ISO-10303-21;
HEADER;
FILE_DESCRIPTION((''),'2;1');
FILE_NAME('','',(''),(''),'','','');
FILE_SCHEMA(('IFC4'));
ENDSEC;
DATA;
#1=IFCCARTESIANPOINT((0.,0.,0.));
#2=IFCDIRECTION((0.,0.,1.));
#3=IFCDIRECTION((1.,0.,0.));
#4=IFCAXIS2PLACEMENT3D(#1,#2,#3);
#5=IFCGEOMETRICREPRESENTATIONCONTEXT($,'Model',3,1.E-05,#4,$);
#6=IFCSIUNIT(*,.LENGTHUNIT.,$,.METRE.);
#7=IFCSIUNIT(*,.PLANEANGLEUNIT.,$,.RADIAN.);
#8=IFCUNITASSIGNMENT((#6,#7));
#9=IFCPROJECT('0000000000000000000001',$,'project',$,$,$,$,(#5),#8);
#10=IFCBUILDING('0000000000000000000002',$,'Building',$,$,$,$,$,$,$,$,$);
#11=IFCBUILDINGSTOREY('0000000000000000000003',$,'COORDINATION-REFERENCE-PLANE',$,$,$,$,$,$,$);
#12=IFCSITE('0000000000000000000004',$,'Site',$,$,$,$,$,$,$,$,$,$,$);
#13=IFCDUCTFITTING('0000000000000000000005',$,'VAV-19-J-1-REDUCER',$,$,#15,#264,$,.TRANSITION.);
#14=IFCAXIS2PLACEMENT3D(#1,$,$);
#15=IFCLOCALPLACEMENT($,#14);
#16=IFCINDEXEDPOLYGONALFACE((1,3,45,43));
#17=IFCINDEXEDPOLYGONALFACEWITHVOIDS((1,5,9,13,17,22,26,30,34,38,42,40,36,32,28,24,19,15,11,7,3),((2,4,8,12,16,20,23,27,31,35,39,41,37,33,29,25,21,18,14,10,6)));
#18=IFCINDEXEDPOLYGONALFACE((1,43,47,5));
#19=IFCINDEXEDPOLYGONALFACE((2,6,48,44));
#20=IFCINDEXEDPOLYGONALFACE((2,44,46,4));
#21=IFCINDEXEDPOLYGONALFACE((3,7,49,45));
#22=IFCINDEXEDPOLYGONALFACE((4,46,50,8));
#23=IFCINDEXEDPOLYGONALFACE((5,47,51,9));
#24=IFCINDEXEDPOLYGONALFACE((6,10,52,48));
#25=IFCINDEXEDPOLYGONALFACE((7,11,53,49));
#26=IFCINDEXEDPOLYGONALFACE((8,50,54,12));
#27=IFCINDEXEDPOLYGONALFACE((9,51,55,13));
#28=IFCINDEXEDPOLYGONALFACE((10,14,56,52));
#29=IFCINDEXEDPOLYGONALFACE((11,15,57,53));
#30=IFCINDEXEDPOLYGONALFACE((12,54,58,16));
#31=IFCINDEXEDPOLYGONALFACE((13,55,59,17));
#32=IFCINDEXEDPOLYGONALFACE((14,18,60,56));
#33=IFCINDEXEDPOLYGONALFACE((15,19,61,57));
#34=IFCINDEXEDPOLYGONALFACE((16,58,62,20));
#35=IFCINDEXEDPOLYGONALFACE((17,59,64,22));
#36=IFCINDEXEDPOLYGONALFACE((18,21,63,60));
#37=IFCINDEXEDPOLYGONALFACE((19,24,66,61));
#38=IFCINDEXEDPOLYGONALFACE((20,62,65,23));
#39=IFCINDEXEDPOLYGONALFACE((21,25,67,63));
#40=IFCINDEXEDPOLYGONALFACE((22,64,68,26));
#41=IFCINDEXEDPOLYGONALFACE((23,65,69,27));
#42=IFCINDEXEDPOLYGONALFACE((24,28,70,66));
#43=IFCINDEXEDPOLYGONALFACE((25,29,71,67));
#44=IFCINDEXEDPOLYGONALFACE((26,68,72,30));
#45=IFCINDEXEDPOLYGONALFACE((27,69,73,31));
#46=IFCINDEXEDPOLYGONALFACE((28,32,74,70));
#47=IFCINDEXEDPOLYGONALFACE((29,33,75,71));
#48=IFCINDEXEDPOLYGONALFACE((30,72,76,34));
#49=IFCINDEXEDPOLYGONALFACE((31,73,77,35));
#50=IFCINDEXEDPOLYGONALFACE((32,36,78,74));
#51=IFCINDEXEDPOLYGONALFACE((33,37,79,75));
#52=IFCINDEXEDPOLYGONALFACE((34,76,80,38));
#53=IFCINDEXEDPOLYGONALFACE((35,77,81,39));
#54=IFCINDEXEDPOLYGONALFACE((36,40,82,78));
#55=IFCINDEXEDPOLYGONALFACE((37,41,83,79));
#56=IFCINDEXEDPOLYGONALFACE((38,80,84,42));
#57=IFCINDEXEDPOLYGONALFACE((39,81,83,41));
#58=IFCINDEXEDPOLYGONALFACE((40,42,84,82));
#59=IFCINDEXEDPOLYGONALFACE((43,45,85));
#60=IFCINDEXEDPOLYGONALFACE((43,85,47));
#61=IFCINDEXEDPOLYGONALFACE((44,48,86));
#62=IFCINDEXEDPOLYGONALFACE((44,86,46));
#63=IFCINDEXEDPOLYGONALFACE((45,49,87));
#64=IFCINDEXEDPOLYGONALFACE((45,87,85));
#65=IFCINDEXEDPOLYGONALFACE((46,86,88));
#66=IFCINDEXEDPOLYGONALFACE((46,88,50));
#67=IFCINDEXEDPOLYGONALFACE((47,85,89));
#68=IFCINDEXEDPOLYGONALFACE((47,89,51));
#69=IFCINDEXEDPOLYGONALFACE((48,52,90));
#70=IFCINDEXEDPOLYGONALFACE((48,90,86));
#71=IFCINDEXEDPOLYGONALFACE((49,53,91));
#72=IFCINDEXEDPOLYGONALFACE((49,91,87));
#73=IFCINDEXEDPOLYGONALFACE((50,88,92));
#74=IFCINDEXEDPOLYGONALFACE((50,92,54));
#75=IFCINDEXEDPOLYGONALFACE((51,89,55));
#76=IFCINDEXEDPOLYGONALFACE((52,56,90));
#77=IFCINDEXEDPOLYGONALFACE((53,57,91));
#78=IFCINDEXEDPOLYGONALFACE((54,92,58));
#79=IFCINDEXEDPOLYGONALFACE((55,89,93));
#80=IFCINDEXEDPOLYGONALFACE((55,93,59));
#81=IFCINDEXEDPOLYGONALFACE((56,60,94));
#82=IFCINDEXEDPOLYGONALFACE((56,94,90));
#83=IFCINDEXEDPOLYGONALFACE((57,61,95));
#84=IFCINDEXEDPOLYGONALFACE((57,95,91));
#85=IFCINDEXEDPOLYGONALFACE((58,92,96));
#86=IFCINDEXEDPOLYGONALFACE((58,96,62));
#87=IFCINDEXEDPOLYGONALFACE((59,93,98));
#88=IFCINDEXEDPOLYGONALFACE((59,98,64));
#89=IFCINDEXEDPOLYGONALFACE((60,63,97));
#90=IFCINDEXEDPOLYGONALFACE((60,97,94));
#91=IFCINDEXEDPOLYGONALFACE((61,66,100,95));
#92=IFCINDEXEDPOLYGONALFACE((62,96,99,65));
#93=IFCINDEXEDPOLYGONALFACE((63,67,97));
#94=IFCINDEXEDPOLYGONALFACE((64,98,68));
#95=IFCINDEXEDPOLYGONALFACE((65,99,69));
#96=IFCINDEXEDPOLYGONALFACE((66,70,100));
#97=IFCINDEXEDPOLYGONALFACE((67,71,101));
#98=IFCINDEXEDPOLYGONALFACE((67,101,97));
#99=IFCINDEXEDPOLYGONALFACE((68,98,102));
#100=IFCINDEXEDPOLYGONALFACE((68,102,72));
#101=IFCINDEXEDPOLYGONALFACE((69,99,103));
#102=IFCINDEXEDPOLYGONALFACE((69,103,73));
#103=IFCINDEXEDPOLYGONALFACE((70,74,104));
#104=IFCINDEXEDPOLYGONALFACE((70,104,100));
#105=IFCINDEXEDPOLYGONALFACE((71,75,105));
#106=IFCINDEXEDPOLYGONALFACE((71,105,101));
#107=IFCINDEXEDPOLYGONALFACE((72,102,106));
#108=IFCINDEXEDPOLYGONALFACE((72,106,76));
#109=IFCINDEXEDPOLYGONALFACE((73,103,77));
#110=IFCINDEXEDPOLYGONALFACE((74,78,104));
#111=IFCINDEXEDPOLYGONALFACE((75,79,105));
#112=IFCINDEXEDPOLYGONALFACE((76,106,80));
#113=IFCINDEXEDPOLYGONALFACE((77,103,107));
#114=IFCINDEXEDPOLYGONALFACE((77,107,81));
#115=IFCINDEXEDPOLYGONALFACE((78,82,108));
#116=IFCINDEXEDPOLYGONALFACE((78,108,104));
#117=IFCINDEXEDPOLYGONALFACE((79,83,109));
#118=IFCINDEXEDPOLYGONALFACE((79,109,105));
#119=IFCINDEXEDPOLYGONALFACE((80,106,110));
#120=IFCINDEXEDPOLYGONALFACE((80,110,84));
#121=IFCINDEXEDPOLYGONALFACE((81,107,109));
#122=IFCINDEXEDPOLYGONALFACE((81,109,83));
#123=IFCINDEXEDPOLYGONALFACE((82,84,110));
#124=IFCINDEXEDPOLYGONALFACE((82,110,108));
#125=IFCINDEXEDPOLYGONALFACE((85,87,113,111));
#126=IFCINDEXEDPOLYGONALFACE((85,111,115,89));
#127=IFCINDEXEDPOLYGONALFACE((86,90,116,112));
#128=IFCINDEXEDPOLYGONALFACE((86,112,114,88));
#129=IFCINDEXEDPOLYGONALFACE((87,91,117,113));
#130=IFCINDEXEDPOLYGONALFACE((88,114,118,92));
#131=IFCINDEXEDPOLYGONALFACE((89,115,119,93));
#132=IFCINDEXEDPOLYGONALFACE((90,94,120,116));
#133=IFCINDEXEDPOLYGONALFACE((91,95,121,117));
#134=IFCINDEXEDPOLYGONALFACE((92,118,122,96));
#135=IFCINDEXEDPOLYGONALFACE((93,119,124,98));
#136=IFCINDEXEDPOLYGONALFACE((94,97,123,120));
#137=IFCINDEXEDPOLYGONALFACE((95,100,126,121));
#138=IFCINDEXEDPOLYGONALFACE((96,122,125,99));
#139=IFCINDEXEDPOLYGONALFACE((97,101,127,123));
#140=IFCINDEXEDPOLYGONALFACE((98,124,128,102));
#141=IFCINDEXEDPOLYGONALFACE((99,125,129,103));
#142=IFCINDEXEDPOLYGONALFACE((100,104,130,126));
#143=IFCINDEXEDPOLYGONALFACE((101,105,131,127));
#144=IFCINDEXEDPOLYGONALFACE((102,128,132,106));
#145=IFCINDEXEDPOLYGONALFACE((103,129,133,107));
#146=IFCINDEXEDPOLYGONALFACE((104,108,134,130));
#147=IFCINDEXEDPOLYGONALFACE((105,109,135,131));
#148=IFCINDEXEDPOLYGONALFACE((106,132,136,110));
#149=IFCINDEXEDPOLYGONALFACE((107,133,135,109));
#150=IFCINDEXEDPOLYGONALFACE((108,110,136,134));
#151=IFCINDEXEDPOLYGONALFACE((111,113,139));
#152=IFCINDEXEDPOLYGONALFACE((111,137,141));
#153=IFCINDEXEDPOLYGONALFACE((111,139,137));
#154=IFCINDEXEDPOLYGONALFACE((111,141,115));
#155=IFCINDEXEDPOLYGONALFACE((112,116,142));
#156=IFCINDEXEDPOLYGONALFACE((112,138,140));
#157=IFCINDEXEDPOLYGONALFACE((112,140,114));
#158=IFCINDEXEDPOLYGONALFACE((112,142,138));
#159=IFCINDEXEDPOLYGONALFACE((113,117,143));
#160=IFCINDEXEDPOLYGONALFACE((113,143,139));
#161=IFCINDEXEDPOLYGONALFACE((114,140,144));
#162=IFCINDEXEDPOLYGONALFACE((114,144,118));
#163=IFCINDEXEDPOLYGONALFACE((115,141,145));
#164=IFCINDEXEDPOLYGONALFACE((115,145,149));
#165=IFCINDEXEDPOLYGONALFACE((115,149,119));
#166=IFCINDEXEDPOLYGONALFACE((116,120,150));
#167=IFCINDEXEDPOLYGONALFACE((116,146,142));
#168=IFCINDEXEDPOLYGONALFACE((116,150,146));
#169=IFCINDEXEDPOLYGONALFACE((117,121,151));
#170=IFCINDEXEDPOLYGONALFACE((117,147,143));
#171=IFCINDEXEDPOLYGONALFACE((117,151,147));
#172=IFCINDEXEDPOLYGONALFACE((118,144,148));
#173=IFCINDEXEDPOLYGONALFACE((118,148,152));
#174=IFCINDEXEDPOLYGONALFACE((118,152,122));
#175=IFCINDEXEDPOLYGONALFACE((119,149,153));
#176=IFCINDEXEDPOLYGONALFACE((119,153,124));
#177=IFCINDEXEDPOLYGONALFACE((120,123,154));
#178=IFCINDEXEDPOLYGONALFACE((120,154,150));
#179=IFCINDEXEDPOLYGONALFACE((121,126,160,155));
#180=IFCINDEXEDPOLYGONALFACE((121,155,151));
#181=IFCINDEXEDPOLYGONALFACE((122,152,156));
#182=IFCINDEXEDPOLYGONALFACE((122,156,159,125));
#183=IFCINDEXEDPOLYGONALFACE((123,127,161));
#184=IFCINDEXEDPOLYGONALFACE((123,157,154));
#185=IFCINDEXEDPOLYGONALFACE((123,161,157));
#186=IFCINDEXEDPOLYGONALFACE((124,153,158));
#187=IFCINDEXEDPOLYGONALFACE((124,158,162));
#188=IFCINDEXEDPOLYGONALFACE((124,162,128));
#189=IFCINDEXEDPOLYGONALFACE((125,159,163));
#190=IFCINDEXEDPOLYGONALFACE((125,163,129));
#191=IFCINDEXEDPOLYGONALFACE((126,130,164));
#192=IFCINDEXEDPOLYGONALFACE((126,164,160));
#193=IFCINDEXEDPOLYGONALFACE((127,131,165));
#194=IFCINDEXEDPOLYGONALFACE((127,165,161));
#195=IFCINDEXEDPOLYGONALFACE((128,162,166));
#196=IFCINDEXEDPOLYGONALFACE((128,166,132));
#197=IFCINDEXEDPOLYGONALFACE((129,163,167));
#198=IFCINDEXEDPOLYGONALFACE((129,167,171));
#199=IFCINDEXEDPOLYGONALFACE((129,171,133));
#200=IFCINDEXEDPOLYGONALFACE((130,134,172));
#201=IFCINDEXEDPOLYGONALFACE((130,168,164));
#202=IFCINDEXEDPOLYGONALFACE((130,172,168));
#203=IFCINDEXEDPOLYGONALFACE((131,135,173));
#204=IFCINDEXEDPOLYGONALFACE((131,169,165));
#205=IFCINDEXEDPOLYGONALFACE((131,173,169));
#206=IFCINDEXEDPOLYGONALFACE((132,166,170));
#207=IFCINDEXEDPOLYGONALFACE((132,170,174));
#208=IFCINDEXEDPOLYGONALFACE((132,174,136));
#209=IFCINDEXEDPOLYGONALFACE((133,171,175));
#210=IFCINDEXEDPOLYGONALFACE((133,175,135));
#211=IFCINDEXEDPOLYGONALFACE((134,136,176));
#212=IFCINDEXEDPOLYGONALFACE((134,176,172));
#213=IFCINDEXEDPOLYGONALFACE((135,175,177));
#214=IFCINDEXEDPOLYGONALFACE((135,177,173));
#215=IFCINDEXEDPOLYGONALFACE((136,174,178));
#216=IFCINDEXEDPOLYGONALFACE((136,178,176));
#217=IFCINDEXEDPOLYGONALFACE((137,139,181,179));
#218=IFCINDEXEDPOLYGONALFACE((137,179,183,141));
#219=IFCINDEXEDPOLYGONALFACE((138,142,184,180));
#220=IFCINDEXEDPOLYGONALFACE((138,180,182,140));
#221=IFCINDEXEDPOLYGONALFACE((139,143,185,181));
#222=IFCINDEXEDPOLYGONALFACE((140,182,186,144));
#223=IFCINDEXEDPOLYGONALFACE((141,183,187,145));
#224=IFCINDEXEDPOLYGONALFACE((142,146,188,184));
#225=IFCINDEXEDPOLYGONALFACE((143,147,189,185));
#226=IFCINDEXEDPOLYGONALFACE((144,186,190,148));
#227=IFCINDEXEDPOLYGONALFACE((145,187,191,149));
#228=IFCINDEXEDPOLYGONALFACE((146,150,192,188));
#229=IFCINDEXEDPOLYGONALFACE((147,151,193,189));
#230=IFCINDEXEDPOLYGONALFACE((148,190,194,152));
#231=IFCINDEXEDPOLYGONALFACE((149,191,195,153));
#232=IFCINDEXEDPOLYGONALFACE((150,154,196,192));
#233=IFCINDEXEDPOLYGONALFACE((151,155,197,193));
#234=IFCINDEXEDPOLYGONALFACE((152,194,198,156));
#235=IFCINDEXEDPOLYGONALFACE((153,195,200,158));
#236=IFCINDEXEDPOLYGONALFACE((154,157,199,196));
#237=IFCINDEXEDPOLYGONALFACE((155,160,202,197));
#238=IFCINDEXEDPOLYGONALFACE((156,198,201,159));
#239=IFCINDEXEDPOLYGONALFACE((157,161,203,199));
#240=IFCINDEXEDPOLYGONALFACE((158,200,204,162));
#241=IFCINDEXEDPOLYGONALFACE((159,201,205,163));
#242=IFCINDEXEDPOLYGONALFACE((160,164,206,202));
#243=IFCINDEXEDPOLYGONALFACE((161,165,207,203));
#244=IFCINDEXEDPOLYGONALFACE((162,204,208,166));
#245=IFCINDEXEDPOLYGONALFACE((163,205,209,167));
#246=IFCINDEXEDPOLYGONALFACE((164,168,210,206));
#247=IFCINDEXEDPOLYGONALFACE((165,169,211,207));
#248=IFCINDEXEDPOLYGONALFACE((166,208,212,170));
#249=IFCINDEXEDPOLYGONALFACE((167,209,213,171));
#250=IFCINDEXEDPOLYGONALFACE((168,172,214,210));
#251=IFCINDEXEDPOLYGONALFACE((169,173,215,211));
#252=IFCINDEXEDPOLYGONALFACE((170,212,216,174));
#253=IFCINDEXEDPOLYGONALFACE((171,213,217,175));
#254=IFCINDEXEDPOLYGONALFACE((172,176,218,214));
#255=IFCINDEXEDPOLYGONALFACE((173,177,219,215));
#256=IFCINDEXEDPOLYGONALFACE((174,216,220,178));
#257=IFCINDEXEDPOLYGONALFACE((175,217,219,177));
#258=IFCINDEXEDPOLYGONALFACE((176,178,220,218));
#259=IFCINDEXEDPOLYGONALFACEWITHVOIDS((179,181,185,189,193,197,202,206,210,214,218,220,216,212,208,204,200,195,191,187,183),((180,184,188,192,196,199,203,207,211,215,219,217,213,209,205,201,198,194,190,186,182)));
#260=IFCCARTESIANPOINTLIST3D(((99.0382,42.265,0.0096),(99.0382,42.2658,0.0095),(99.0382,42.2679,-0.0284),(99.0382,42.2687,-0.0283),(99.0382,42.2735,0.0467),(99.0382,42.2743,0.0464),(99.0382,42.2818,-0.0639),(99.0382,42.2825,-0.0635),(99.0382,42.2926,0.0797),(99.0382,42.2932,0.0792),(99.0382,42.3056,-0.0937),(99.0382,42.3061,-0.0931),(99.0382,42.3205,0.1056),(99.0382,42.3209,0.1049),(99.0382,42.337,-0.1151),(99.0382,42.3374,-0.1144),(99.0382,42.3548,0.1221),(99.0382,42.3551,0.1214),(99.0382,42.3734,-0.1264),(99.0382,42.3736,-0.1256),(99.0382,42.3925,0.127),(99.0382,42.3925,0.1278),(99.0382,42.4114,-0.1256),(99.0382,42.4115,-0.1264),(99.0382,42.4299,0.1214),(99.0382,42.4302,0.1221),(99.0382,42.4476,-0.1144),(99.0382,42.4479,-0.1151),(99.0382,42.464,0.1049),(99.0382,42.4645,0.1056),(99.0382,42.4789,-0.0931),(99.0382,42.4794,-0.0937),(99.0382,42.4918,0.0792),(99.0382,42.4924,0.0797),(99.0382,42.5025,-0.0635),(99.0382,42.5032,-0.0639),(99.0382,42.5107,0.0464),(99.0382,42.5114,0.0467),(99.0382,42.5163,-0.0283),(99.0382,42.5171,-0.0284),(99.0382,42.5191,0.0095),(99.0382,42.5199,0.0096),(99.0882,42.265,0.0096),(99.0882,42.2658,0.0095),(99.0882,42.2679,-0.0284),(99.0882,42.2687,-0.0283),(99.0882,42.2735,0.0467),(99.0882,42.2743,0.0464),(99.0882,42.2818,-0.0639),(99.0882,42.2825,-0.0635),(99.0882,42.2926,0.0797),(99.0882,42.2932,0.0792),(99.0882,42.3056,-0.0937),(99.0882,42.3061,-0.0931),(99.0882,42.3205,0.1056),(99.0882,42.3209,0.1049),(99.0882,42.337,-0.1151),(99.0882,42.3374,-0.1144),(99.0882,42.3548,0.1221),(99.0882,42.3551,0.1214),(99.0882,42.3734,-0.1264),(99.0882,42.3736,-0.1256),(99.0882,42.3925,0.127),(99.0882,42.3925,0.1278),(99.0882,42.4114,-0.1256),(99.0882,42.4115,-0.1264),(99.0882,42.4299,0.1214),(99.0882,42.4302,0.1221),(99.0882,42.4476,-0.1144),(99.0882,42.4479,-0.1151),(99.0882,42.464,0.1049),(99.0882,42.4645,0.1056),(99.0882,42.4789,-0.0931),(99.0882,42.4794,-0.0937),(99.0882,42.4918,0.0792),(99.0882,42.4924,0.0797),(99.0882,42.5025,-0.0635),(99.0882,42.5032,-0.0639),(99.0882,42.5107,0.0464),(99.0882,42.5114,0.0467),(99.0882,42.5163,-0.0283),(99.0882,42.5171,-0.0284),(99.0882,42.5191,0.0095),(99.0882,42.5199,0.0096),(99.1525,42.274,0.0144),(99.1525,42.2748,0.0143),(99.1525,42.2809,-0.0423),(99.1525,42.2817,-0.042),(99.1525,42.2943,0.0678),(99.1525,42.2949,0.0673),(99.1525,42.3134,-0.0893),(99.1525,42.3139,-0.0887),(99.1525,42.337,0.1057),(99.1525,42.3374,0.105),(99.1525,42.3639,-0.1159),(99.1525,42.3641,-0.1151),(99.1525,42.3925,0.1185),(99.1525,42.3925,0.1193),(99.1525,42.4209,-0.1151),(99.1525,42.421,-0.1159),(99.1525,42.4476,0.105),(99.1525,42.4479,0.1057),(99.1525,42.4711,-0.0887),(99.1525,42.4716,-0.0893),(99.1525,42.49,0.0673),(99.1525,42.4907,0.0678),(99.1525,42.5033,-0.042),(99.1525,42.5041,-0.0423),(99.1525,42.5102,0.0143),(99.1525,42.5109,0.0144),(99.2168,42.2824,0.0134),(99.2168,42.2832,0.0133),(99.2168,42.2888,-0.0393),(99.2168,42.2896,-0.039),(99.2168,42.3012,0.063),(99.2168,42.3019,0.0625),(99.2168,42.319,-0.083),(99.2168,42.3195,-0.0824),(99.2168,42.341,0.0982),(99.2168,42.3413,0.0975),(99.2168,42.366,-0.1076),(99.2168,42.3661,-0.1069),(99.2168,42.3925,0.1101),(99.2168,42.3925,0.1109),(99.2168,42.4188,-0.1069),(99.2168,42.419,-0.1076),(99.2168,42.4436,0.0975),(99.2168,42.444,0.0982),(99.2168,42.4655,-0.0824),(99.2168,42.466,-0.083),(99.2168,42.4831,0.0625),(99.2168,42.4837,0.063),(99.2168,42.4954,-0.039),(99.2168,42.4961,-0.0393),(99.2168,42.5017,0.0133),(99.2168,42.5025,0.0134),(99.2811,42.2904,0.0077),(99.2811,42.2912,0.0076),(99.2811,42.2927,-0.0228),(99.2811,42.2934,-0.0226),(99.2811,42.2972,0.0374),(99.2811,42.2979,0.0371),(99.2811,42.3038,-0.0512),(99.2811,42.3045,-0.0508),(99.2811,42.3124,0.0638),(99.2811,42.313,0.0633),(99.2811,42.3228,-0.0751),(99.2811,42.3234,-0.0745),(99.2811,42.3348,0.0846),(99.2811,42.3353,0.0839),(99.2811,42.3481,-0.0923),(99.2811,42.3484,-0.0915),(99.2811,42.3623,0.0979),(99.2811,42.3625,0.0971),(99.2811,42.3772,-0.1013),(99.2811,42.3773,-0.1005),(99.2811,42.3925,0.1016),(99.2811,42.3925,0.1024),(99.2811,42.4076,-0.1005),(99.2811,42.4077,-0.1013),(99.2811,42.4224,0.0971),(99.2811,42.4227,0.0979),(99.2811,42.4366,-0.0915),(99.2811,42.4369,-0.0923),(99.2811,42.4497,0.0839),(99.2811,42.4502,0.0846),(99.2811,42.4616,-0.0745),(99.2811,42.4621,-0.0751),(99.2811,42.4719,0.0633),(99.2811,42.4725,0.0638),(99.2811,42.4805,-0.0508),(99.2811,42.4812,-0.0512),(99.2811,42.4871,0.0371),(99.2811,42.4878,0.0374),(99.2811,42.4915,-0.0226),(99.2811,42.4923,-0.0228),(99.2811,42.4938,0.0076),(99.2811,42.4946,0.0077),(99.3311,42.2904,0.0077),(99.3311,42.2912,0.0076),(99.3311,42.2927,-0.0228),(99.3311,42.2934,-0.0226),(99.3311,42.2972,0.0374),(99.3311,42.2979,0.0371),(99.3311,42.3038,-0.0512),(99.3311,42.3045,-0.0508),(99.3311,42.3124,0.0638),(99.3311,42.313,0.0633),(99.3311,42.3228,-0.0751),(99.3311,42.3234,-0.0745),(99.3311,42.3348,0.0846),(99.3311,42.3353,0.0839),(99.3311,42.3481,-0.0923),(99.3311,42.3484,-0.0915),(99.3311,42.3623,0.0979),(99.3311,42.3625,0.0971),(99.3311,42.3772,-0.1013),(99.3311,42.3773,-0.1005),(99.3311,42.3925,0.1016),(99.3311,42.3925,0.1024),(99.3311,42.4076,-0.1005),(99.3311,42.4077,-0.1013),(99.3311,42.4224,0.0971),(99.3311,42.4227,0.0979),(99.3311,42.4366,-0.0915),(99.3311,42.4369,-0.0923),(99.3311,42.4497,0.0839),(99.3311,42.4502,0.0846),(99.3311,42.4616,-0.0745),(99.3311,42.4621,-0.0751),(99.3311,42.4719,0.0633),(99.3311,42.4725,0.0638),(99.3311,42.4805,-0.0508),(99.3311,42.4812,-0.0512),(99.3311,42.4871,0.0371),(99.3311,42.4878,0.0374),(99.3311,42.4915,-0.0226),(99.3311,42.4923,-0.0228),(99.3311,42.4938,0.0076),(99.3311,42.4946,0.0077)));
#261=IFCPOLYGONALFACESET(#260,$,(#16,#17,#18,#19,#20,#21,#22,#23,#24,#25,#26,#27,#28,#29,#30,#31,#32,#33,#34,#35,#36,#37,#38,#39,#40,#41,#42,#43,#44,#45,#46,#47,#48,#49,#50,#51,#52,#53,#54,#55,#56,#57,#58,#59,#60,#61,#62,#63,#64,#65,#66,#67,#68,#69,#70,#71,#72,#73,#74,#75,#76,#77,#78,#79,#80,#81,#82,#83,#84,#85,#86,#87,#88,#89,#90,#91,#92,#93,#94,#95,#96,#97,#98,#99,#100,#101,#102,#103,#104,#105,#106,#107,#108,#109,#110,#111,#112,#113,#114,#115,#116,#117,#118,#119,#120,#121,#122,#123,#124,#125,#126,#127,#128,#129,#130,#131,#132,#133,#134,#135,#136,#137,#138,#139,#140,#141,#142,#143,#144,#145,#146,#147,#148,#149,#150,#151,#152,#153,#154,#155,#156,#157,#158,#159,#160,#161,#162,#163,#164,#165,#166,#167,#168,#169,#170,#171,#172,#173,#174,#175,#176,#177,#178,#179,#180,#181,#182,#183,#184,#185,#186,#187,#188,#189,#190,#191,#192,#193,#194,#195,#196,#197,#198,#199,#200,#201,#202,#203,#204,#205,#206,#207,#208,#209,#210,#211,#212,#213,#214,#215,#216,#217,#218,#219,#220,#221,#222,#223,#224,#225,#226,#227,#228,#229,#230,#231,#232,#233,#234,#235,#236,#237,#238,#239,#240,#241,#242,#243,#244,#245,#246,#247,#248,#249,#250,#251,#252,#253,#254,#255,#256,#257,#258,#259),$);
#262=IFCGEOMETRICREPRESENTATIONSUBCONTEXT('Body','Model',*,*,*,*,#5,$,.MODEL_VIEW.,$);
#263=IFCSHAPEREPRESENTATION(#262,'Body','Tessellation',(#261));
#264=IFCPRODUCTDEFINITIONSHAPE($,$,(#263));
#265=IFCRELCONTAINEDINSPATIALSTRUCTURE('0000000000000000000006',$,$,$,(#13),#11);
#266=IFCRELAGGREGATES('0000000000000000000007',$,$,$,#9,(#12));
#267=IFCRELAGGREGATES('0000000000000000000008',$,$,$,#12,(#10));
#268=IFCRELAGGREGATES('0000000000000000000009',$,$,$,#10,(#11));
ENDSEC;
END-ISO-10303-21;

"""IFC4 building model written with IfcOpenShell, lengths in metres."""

from ifc_helpers import new_model, entity, si_unit, frame, origin_with_axes, place, context, subcontext, project, spatial, element, save


model = new_model("IFC4")

# Units and contexts
model_context = context("Model", 3, precision=1e-05, world=origin_with_axes())
body_context_1 = subcontext(model_context, "Body", "Model", "MODEL_VIEW")
ifc_project = project(units=[si_unit("LENGTHUNIT", "METRE"), si_unit("PLANEANGLEUNIT", "RADIAN")], contexts=[model_context])

# Site, building, storey
site = spatial("IfcSite", under=ifc_project, Name="Site")
building = spatial("IfcBuilding", under=site, Name="Building")
storey = spatial("IfcBuildingStorey", under=building, Name="COORDINATION-REFERENCE-PLANE")

# Duct fitting
for number, where, z_axis, x_axis, name in (
    (1, (99.0382, 42.3925, 0.0), (0.0, 1.0, 0.0), (0.0, 0.0, 1.0), "VAV-19-J-1-REDUCER"),
):
    element("IfcDuctFitting", number, at=place(None, frame(where, z_axis=z_axis, x_axis=x_axis)), inside=storey, Name=name, PredefinedType="TRANSITION", context=body_context_1, shape_type="SweptSolid", body=[
        entity("IfcRevolvedAreaSolid", entity("IfcArbitraryClosedProfileDef", "AREA", None, entity("IfcPolyline", [entity("IfcCartesianPoint", [0.1278, 0.0]), entity("IfcCartesianPoint", [0.1278, 0.05]), entity("IfcCartesianPoint", [0.1024, 0.2429]), entity("IfcCartesianPoint", [0.1024, 0.2929]), entity("IfcCartesianPoint", [0.1016, 0.2929]), entity("IfcCartesianPoint", [0.1016, 0.2429]), entity("IfcCartesianPoint", [0.127, 0.05]), entity("IfcCartesianPoint", [0.127, 0.0]), entity("IfcCartesianPoint", [0.1278, 0.0])])), entity("IfcAxis2Placement3D", entity("IfcCartesianPoint", [0.0, 0.0, 0.0])), entity("IfcAxis1Placement", entity("IfcCartesianPoint", [0.0, 0.0, 0.0]), entity("IfcDirection", [0.0, 1.0, 0.0])), 6.283185),
    ])

save(model, "model.ifc")
